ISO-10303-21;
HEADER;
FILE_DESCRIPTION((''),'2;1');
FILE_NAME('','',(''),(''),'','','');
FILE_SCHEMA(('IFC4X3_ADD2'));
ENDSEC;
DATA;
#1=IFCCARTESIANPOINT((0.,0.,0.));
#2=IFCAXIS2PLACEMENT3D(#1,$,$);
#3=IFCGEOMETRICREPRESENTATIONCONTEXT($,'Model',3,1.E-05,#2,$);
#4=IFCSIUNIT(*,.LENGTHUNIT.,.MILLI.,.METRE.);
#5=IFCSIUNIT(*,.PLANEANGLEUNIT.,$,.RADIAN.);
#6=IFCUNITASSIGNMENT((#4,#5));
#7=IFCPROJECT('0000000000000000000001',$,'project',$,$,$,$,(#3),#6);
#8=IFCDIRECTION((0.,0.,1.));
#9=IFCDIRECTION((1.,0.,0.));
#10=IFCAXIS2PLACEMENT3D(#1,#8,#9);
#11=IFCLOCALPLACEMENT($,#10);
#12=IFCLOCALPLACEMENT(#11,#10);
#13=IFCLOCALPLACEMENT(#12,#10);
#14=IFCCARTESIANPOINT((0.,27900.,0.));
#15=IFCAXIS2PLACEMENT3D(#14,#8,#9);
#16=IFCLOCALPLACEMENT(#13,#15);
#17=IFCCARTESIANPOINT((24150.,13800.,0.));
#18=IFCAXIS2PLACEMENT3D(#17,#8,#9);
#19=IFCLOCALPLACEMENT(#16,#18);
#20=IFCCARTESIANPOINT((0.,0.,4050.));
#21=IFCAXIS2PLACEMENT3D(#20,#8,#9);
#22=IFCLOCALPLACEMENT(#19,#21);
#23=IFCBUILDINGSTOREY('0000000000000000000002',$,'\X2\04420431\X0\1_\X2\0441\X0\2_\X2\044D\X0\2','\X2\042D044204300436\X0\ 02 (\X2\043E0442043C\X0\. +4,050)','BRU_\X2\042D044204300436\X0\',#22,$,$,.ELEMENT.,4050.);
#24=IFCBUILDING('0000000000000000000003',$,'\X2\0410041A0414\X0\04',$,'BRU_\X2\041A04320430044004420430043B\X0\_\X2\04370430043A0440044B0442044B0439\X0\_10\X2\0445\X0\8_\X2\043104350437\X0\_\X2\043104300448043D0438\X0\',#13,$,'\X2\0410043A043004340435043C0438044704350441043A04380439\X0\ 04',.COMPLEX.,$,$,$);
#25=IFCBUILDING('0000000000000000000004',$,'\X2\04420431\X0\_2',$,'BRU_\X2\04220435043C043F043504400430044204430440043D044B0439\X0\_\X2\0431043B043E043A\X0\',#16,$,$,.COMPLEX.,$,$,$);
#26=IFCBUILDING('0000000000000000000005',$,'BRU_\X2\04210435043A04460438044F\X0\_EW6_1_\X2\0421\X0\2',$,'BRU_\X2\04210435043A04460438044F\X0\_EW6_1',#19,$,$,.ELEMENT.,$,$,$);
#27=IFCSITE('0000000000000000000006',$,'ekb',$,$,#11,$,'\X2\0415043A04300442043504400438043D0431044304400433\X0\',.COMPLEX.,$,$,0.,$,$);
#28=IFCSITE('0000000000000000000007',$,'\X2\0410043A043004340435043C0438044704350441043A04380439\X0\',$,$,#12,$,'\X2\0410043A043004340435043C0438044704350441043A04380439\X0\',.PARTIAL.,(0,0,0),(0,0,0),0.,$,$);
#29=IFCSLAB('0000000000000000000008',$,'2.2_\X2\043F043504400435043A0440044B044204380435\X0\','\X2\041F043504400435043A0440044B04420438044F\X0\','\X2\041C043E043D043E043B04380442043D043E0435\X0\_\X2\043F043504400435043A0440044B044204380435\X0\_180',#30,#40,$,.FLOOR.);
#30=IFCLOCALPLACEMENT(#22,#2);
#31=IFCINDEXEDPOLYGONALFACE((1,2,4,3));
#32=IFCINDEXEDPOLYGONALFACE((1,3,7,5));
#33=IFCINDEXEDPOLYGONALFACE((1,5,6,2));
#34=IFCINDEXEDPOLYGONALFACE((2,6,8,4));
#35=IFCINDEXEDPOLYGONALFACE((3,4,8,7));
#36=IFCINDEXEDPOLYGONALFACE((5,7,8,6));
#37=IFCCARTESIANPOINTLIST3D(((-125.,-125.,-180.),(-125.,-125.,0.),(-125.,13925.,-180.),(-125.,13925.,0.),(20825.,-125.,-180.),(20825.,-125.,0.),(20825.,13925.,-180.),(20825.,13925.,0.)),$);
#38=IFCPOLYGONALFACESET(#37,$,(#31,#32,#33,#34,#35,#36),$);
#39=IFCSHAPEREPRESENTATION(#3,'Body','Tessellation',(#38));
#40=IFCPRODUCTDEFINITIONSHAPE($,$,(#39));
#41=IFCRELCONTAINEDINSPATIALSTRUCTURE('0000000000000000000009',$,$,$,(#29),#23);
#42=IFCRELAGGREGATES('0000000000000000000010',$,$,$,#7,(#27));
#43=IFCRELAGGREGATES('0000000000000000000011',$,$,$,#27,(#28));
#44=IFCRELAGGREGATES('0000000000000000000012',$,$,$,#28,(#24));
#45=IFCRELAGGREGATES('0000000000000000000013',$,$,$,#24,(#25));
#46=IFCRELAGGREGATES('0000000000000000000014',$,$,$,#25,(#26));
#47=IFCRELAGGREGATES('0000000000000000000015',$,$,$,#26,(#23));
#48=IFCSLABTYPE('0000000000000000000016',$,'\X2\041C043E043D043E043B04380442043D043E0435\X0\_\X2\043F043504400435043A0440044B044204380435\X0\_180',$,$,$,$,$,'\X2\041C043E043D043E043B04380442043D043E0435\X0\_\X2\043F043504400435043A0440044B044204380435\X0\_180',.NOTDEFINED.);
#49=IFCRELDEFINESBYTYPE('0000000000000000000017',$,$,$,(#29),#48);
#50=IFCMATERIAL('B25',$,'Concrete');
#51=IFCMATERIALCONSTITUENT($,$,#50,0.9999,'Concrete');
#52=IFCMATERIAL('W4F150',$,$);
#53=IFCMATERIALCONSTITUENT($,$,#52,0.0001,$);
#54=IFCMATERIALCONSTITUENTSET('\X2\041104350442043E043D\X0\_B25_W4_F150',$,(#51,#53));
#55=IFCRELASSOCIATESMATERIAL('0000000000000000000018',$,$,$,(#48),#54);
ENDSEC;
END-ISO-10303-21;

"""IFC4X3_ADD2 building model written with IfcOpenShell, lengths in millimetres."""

from ifc_helpers import new_model, si_unit, frame, origin, origin_with_axes, place, context, project, spatial, polyline, outline, extrude, material, constituent, constituent_set, type_object, element, save


model = new_model("IFC4X3_ADD2")

# Units and contexts
model_context = context("Model", 3, precision=1e-05, world=origin())
ifc_project = project(units=[si_unit("LENGTHUNIT", "METRE", prefix="MILLI"), si_unit("PLANEANGLEUNIT", "RADIAN")], contexts=[model_context])

# Sites, buildings, storey
site_1_placement = place(None, origin_with_axes())
site_1 = spatial("IfcSite", under=ifc_project, at=site_1_placement, Name="ekb", LongName="Екатеринбург", CompositionType="COMPLEX", RefElevation=0.0)
site_2_placement = place(site_1_placement, origin_with_axes())
site_2 = spatial("IfcSite", under=site_1, at=site_2_placement, Name="Академический", LongName="Академический", CompositionType="PARTIAL", RefLatitude=(0, 0, 0), RefLongitude=(0, 0, 0), RefElevation=0.0)
building_1_placement = place(site_2_placement, origin_with_axes())
building_1 = spatial("IfcBuilding", under=site_2, at=building_1_placement, Name="АКД04", ObjectType="BRU_Квартал_закрытый_10х8_без_башни", LongName="Академический 04", CompositionType="COMPLEX")
building_2_placement = place(building_1_placement, frame((0.0, 27900.0, 0.0), z_axis=(0.0, 0.0, 1.0), x_axis=(1.0, 0.0, 0.0)))
building_2 = spatial("IfcBuilding", under=building_1, at=building_2_placement, Name="тб_2", ObjectType="BRU_Температурный_блок", CompositionType="COMPLEX")
building_3_placement = place(building_2_placement, frame((24150.0, 13800.0, 0.0), z_axis=(0.0, 0.0, 1.0), x_axis=(1.0, 0.0, 0.0)))
building_3 = spatial("IfcBuilding", under=building_2, at=building_3_placement, Name="BRU_Секция_EW6_1_С2", ObjectType="BRU_Секция_EW6_1", CompositionType="ELEMENT")
storey_placement = place(building_3_placement, frame((0.0, 0.0, 4050.0), z_axis=(0.0, 0.0, 1.0), x_axis=(1.0, 0.0, 0.0)))
storey = spatial("IfcBuildingStorey", under=building_3, at=storey_placement, Name="тб1_с2_э2", Description="Этаж 02 (отм. +4,050)", ObjectType="BRU_Этаж", CompositionType="ELEMENT", Elevation=4050.0)

# Shared definitions
ifc_material_1 = material(Name="B25", Category="Concrete")
ifc_material_2 = material(Name="W4F150")

# Slab
ifc_constituent_1 = constituent(ifc_material_1, Category="Concrete", fraction=0.9999)
ifc_constituent_2 = constituent(ifc_material_2, fraction=0.0001)
ifc_constituent_set_1 = constituent_set(constituents=[ifc_constituent_1, ifc_constituent_2], Name="Бетон_B25_W4_F150")
slab_type = type_object("IfcSlabType", Name="Монолитное_перекрытие_180", ElementType="Монолитное_перекрытие_180", PredefinedType="NOTDEFINED", material=ifc_constituent_set_1)
slab_placement = place(storey_placement, frame((0.0, 0.0, -180.0), z_axis=(0.0, 0.0, 1.0), x_axis=(1.0, 0.0, 0.0)))
element("IfcSlab", 1, at=slab_placement, inside=storey, type_object=slab_type, Name="2.2_перекрытие", Description="Перекрытия", ObjectType="Монолитное_перекрытие_180", PredefinedType="FLOOR", context=model_context, shape_type="SweptSolid", body=[
    extrude(outline(polyline([(-125.0, -125.0), (20825.0, -125.0), (20825.0, 13925.0), (-125.0, 13925.0), (-125.0, -125.0)])), origin_with_axes(), (0.0, 0.0, 1.0), 180.0),
])

save(model, "model.ifc")
